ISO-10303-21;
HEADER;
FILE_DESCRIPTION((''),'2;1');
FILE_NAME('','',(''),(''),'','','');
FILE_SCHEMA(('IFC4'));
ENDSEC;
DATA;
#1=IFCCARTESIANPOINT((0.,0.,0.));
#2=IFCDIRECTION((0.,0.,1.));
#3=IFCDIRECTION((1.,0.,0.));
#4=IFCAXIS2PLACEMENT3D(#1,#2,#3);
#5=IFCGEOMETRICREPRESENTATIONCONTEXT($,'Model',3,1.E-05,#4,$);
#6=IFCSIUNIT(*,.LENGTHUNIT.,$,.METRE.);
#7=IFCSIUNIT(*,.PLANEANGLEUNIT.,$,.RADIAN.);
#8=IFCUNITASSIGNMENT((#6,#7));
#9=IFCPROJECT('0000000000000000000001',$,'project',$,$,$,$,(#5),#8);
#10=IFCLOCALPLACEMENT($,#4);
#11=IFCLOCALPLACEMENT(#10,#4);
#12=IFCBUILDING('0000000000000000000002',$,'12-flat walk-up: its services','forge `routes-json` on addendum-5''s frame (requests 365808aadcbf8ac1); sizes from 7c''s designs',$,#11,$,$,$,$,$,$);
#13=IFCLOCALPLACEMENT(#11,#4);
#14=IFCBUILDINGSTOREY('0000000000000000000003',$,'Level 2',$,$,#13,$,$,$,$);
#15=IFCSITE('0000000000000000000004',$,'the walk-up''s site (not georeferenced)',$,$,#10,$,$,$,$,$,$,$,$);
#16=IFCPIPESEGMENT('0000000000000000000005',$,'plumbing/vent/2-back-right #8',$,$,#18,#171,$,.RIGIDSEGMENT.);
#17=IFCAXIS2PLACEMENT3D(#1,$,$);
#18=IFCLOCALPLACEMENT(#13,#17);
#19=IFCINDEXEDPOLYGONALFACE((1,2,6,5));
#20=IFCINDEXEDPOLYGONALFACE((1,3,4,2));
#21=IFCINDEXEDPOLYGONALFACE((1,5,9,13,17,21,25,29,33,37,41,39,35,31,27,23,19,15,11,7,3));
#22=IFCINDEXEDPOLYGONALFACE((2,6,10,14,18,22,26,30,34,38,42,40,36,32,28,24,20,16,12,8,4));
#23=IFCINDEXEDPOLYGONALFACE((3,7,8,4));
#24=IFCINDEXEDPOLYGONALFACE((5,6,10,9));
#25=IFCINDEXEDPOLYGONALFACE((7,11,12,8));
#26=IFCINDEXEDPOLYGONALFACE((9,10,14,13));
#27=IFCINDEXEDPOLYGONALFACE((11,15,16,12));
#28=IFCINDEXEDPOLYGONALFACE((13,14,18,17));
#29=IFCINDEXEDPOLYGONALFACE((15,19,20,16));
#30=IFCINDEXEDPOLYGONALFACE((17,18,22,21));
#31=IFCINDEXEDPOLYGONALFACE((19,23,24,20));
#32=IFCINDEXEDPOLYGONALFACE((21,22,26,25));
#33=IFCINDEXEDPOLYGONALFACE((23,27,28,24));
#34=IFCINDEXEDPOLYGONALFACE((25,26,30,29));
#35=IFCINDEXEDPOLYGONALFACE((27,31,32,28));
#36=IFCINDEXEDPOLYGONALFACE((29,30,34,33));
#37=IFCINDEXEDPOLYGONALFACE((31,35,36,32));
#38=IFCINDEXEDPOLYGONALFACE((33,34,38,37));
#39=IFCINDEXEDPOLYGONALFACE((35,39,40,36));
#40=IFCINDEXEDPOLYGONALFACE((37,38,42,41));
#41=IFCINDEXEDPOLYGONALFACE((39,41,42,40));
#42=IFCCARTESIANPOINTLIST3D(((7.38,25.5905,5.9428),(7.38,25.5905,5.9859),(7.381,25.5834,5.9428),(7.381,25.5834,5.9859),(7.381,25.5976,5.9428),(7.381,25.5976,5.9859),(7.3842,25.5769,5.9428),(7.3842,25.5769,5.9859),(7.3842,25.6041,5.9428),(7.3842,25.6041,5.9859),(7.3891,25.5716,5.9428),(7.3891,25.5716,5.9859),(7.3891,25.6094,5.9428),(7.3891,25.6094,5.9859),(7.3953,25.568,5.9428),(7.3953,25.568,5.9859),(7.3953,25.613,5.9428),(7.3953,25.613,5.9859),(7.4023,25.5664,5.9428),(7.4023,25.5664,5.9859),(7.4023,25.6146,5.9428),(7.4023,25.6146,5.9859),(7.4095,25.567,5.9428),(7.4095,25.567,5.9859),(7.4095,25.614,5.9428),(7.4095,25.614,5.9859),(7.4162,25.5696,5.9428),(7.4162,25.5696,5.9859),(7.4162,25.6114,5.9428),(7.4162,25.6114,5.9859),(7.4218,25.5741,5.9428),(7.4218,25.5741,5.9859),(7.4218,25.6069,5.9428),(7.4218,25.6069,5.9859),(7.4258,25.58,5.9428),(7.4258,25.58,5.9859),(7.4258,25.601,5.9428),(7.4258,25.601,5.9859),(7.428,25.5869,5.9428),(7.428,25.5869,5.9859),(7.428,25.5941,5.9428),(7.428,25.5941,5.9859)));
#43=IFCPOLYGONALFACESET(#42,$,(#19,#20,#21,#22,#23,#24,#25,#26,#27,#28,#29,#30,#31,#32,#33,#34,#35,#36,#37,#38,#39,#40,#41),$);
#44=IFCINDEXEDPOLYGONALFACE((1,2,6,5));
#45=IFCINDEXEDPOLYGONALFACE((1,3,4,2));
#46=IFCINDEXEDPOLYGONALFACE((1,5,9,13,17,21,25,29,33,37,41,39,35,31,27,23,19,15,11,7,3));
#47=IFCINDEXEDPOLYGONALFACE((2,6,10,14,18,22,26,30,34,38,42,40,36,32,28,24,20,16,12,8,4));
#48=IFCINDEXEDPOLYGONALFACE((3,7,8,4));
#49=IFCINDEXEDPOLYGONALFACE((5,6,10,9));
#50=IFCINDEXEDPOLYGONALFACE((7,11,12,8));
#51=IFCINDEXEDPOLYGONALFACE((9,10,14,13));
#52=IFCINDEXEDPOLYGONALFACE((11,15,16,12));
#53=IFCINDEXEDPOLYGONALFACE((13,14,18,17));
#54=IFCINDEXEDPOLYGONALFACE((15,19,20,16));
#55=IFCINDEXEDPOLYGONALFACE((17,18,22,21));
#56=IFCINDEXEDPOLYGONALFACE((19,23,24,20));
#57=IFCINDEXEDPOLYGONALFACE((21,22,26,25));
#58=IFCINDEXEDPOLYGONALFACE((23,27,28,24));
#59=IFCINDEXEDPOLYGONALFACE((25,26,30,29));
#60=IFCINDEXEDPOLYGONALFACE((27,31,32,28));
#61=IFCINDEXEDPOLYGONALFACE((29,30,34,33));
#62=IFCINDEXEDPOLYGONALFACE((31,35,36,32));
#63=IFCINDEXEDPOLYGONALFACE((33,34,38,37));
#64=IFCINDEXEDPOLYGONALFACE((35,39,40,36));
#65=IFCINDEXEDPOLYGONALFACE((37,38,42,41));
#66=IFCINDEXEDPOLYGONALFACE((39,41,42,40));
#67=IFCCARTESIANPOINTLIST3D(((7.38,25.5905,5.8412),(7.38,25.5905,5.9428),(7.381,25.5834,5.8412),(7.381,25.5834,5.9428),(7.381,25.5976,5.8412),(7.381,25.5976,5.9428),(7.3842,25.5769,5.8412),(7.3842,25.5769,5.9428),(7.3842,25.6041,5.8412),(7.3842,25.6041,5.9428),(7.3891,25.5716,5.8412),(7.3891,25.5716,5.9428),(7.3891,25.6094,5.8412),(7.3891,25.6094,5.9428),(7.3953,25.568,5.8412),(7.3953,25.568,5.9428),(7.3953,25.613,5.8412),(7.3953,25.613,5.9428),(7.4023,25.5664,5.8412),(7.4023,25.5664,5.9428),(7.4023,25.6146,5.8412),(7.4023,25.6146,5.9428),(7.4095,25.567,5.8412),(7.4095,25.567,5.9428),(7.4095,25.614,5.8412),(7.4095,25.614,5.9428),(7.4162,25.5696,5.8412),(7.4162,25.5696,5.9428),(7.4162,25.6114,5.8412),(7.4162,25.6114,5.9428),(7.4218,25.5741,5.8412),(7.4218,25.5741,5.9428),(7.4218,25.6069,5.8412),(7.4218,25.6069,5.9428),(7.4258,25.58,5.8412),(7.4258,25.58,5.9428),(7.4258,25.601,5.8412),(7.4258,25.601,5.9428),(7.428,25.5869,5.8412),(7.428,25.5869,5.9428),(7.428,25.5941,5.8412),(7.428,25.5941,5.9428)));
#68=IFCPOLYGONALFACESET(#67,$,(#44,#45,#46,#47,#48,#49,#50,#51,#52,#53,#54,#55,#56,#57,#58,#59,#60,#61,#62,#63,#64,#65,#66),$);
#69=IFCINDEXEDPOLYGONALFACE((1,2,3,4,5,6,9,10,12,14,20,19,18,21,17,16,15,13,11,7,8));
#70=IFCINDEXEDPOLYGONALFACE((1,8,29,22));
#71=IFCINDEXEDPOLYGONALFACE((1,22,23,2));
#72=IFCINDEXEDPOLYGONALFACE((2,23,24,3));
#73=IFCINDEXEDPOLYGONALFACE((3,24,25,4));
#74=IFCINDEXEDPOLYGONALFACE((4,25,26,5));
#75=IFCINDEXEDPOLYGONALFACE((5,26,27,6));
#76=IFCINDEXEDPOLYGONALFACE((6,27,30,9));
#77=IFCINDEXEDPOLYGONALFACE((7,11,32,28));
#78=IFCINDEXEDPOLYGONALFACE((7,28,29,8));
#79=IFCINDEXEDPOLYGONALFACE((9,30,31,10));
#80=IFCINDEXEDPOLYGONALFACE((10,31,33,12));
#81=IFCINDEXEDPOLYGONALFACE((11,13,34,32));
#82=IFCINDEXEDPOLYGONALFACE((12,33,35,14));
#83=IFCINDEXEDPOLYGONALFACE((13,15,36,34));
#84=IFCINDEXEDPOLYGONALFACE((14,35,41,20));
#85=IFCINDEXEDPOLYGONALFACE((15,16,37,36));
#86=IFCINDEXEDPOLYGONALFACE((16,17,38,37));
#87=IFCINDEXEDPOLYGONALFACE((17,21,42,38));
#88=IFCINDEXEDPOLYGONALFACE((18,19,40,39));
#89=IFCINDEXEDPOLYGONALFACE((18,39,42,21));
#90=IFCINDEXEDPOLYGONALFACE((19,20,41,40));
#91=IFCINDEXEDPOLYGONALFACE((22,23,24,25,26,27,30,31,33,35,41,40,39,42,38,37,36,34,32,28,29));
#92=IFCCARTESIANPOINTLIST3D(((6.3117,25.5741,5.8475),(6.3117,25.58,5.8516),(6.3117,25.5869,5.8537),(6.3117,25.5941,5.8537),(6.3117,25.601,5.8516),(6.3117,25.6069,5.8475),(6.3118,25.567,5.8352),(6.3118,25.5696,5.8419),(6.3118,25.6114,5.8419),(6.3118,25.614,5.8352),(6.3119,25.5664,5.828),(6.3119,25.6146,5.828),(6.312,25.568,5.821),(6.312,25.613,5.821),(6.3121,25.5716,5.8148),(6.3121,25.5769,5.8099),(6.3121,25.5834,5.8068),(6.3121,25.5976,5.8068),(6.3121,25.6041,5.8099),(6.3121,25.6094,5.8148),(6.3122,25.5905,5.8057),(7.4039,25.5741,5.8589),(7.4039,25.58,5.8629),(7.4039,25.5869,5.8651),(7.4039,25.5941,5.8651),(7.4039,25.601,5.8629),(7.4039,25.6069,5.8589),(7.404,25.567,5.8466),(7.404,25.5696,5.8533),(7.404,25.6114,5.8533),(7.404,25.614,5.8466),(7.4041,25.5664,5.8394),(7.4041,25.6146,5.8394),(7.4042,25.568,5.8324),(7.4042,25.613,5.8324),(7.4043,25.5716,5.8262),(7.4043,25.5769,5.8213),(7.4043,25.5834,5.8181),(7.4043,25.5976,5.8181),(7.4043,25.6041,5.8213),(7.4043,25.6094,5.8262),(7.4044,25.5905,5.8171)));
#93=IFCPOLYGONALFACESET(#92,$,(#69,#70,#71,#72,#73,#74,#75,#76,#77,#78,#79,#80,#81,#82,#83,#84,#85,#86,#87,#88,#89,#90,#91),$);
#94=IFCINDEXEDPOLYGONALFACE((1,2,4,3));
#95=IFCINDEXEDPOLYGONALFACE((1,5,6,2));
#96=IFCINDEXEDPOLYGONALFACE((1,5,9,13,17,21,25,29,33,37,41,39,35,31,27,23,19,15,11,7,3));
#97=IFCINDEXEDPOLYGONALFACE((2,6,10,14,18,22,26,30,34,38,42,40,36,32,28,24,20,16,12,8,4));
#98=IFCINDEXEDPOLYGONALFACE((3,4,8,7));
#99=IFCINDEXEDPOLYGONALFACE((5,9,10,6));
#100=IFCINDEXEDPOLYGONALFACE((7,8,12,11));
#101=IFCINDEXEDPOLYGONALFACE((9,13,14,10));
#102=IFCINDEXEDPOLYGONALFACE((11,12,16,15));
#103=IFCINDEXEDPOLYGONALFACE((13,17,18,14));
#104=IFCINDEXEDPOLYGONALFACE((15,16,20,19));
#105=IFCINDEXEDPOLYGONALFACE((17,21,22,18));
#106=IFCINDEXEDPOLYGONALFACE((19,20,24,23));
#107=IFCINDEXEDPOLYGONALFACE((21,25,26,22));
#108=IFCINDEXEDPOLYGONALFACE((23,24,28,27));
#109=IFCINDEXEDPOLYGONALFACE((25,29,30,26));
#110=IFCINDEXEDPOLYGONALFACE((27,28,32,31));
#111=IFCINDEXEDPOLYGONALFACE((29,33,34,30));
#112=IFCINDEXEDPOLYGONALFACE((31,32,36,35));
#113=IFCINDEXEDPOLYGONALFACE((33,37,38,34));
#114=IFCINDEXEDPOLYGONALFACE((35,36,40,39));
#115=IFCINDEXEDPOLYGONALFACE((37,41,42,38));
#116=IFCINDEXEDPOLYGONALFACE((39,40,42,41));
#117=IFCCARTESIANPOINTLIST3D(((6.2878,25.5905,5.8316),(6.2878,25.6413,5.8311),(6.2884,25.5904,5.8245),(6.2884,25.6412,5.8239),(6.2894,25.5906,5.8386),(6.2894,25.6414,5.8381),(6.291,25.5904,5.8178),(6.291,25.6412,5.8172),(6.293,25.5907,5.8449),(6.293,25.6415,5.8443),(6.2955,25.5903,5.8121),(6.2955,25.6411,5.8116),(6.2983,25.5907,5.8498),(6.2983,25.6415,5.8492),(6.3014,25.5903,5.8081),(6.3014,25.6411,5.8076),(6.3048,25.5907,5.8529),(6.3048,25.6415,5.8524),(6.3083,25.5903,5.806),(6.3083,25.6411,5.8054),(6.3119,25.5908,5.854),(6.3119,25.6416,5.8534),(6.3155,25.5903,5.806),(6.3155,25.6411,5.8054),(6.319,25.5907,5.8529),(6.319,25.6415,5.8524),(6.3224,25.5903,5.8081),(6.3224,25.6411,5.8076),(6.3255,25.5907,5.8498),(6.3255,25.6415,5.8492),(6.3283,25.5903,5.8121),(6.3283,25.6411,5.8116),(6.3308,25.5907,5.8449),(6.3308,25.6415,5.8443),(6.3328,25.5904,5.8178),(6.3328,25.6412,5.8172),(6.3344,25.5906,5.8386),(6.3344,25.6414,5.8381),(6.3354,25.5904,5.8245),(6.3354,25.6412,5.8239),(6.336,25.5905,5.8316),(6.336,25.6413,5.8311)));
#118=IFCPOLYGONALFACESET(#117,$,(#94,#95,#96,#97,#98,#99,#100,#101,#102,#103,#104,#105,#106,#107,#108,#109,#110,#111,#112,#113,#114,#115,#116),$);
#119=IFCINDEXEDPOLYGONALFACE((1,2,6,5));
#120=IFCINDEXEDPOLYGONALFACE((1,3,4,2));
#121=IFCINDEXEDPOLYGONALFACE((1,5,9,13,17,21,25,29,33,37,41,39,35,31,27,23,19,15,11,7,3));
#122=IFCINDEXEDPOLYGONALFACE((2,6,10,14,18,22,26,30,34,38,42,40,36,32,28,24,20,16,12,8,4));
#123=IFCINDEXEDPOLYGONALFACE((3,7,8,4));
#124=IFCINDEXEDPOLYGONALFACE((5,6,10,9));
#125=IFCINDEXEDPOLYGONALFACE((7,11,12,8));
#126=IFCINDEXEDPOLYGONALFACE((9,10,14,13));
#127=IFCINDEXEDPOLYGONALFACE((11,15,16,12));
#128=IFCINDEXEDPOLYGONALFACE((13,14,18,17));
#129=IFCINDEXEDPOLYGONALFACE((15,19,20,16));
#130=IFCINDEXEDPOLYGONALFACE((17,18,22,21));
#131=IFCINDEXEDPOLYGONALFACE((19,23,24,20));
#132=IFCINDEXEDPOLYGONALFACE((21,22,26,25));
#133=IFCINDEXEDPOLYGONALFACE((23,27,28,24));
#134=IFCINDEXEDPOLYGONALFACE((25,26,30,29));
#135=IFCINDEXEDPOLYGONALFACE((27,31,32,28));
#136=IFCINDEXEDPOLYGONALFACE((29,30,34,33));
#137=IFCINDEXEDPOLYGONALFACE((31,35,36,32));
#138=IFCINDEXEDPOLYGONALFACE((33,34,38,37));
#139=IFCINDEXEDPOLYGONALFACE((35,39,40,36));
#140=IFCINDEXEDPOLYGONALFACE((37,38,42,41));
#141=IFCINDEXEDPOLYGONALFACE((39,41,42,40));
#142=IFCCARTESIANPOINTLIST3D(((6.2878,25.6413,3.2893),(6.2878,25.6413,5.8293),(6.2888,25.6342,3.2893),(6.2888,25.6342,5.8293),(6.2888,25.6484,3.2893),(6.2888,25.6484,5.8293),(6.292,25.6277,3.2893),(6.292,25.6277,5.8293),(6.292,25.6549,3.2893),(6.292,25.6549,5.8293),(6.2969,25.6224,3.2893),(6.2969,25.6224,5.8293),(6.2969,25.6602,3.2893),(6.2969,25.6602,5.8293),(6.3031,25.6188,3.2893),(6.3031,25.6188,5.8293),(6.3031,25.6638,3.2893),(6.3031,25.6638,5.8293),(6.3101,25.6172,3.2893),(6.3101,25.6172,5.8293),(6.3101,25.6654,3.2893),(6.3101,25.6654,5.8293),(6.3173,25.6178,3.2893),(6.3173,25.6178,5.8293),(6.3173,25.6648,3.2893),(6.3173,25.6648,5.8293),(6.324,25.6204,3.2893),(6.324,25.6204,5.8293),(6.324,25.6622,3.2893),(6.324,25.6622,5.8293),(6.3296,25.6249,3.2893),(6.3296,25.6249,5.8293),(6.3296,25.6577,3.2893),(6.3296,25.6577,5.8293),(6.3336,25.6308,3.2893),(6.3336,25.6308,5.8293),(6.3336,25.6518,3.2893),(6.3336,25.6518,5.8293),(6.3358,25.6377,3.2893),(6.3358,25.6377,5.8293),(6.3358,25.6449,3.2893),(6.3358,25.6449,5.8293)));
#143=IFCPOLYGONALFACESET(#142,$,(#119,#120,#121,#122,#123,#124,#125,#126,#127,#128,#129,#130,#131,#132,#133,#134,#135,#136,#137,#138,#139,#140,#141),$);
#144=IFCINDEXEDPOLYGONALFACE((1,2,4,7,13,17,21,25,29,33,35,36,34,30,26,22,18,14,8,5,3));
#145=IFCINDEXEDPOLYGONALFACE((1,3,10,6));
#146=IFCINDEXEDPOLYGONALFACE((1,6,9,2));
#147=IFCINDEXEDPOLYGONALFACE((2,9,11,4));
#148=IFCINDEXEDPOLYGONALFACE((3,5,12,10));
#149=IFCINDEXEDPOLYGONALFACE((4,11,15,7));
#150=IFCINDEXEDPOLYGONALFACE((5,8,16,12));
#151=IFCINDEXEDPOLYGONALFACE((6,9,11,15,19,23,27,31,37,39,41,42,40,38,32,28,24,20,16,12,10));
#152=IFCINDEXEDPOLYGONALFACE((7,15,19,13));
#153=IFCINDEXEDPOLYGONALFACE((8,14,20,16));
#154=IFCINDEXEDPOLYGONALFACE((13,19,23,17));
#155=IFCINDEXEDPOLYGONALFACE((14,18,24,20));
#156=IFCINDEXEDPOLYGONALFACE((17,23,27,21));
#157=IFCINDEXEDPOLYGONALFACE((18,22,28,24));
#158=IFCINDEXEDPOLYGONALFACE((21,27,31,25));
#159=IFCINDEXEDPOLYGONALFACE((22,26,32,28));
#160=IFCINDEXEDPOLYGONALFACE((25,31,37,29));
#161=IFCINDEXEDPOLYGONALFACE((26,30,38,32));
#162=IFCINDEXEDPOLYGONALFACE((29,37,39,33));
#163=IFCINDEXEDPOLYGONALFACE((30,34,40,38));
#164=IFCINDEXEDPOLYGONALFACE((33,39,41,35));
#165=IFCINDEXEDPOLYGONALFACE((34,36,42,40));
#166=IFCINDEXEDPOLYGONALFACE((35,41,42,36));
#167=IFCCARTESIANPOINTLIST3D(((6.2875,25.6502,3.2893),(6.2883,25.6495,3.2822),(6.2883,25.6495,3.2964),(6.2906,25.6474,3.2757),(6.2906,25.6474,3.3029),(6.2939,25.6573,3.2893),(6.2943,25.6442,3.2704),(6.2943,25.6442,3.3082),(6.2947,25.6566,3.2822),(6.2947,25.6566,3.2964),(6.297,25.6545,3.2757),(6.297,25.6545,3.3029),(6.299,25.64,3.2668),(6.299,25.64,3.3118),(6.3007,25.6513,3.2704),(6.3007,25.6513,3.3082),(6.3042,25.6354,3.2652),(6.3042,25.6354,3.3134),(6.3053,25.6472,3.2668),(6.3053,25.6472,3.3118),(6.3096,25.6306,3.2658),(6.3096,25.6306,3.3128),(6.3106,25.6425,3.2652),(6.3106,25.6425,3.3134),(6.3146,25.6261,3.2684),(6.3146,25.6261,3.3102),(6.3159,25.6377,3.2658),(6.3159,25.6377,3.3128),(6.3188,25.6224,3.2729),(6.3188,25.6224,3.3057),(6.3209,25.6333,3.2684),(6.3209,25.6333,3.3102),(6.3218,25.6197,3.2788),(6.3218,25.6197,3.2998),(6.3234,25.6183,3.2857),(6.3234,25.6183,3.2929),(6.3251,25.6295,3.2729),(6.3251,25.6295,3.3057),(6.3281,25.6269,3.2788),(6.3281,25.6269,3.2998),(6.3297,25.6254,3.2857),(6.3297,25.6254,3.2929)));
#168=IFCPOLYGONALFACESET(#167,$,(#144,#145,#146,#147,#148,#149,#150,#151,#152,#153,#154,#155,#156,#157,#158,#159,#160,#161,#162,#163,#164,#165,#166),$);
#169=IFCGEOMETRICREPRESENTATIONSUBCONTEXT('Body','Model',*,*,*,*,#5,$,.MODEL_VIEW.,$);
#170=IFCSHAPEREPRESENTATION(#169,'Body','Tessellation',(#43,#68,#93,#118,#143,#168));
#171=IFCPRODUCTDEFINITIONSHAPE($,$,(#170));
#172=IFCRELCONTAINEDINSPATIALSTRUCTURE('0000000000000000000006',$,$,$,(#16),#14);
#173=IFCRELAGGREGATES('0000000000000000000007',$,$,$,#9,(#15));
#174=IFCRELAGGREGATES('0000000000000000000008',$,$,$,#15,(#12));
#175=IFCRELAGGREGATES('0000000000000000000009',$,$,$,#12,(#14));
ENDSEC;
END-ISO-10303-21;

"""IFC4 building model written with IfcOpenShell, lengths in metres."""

from ifc_helpers import new_model, entity, si_unit, frame, origin_with_axes, place, context, subcontext, project, spatial, element, save


model = new_model("IFC4")

# Units and contexts
model_context = context("Model", 3, precision=1e-05, world=origin_with_axes())
body_context = subcontext(model_context, "Body", "Model", "MODEL_VIEW")
ifc_project = project(units=[si_unit("LENGTHUNIT", "METRE"), si_unit("PLANEANGLEUNIT", "RADIAN")], contexts=[model_context])

# Site, building, storey
site_placement = place(None, origin_with_axes())
site = spatial("IfcSite", under=ifc_project, at=site_placement, Name="the walk-up's site (not georeferenced)")
building_placement = place(site_placement, origin_with_axes())
building = spatial("IfcBuilding", under=site, at=building_placement, Name="12-flat walk-up: its services", Description="forge `routes-json` on addendum-5's frame (requests 365808aadcbf8ac1); sizes from 7c's designs")
storey_placement = place(building_placement, origin_with_axes())
storey = spatial("IfcBuildingStorey", under=building, at=storey_placement, Name="Level 2")

# Pipe segment
pipe_segment_1_placement = place(storey_placement, frame((7.4041, 25.5905, 5.9859), z_axis=(0.0, 0.0, 1.0), x_axis=(1.0, 0.0, 0.0)))
element("IfcPipeSegment", 1, at=pipe_segment_1_placement, inside=storey, Name="plumbing/vent/2-back-right #8", PredefinedType="RIGIDSEGMENT", context=body_context, shape_type="AdvancedSweptSolid", body=[
    entity("IfcSweptDiskSolid", entity("IfcPolyline", [entity("IfcCartesianPoint", [0.0, 0.0, 0.0]), entity("IfcCartesianPoint", [0.0, 0.0, -0.0431])]), 0.0241),
    entity("IfcSweptDiskSolid", entity("IfcPolyline", [entity("IfcCartesianPoint", [0.0, 0.0, -0.0431]), entity("IfcCartesianPoint", [0.0, 0.0, -0.1447])]), 0.0241),
    entity("IfcSweptDiskSolid", entity("IfcPolyline", [entity("IfcCartesianPoint", [0.0, 0.0, -0.1447]), entity("IfcCartesianPoint", [-1.0922, 0.0, -0.1561])]), 0.0241),
    entity("IfcSweptDiskSolid", entity("IfcPolyline", [entity("IfcCartesianPoint", [-1.0922, 0.0, -0.1561]), entity("IfcCartesianPoint", [-1.0922, 0.0508, -0.1566])]), 0.0241),
    entity("IfcSweptDiskSolid", entity("IfcPolyline", [entity("IfcCartesianPoint", [-1.0922, 0.0508, -0.1566]), entity("IfcCartesianPoint", [-1.0922, 0.0508, -2.6966])]), 0.0241),
    entity("IfcSweptDiskSolid", entity("IfcPolyline", [entity("IfcCartesianPoint", [-1.0922, 0.0508, -2.6966]), entity("IfcCartesianPoint", [-1.0985, 0.0437, -2.6966])]), 0.0241),
])

save(model, "model.ifc")
